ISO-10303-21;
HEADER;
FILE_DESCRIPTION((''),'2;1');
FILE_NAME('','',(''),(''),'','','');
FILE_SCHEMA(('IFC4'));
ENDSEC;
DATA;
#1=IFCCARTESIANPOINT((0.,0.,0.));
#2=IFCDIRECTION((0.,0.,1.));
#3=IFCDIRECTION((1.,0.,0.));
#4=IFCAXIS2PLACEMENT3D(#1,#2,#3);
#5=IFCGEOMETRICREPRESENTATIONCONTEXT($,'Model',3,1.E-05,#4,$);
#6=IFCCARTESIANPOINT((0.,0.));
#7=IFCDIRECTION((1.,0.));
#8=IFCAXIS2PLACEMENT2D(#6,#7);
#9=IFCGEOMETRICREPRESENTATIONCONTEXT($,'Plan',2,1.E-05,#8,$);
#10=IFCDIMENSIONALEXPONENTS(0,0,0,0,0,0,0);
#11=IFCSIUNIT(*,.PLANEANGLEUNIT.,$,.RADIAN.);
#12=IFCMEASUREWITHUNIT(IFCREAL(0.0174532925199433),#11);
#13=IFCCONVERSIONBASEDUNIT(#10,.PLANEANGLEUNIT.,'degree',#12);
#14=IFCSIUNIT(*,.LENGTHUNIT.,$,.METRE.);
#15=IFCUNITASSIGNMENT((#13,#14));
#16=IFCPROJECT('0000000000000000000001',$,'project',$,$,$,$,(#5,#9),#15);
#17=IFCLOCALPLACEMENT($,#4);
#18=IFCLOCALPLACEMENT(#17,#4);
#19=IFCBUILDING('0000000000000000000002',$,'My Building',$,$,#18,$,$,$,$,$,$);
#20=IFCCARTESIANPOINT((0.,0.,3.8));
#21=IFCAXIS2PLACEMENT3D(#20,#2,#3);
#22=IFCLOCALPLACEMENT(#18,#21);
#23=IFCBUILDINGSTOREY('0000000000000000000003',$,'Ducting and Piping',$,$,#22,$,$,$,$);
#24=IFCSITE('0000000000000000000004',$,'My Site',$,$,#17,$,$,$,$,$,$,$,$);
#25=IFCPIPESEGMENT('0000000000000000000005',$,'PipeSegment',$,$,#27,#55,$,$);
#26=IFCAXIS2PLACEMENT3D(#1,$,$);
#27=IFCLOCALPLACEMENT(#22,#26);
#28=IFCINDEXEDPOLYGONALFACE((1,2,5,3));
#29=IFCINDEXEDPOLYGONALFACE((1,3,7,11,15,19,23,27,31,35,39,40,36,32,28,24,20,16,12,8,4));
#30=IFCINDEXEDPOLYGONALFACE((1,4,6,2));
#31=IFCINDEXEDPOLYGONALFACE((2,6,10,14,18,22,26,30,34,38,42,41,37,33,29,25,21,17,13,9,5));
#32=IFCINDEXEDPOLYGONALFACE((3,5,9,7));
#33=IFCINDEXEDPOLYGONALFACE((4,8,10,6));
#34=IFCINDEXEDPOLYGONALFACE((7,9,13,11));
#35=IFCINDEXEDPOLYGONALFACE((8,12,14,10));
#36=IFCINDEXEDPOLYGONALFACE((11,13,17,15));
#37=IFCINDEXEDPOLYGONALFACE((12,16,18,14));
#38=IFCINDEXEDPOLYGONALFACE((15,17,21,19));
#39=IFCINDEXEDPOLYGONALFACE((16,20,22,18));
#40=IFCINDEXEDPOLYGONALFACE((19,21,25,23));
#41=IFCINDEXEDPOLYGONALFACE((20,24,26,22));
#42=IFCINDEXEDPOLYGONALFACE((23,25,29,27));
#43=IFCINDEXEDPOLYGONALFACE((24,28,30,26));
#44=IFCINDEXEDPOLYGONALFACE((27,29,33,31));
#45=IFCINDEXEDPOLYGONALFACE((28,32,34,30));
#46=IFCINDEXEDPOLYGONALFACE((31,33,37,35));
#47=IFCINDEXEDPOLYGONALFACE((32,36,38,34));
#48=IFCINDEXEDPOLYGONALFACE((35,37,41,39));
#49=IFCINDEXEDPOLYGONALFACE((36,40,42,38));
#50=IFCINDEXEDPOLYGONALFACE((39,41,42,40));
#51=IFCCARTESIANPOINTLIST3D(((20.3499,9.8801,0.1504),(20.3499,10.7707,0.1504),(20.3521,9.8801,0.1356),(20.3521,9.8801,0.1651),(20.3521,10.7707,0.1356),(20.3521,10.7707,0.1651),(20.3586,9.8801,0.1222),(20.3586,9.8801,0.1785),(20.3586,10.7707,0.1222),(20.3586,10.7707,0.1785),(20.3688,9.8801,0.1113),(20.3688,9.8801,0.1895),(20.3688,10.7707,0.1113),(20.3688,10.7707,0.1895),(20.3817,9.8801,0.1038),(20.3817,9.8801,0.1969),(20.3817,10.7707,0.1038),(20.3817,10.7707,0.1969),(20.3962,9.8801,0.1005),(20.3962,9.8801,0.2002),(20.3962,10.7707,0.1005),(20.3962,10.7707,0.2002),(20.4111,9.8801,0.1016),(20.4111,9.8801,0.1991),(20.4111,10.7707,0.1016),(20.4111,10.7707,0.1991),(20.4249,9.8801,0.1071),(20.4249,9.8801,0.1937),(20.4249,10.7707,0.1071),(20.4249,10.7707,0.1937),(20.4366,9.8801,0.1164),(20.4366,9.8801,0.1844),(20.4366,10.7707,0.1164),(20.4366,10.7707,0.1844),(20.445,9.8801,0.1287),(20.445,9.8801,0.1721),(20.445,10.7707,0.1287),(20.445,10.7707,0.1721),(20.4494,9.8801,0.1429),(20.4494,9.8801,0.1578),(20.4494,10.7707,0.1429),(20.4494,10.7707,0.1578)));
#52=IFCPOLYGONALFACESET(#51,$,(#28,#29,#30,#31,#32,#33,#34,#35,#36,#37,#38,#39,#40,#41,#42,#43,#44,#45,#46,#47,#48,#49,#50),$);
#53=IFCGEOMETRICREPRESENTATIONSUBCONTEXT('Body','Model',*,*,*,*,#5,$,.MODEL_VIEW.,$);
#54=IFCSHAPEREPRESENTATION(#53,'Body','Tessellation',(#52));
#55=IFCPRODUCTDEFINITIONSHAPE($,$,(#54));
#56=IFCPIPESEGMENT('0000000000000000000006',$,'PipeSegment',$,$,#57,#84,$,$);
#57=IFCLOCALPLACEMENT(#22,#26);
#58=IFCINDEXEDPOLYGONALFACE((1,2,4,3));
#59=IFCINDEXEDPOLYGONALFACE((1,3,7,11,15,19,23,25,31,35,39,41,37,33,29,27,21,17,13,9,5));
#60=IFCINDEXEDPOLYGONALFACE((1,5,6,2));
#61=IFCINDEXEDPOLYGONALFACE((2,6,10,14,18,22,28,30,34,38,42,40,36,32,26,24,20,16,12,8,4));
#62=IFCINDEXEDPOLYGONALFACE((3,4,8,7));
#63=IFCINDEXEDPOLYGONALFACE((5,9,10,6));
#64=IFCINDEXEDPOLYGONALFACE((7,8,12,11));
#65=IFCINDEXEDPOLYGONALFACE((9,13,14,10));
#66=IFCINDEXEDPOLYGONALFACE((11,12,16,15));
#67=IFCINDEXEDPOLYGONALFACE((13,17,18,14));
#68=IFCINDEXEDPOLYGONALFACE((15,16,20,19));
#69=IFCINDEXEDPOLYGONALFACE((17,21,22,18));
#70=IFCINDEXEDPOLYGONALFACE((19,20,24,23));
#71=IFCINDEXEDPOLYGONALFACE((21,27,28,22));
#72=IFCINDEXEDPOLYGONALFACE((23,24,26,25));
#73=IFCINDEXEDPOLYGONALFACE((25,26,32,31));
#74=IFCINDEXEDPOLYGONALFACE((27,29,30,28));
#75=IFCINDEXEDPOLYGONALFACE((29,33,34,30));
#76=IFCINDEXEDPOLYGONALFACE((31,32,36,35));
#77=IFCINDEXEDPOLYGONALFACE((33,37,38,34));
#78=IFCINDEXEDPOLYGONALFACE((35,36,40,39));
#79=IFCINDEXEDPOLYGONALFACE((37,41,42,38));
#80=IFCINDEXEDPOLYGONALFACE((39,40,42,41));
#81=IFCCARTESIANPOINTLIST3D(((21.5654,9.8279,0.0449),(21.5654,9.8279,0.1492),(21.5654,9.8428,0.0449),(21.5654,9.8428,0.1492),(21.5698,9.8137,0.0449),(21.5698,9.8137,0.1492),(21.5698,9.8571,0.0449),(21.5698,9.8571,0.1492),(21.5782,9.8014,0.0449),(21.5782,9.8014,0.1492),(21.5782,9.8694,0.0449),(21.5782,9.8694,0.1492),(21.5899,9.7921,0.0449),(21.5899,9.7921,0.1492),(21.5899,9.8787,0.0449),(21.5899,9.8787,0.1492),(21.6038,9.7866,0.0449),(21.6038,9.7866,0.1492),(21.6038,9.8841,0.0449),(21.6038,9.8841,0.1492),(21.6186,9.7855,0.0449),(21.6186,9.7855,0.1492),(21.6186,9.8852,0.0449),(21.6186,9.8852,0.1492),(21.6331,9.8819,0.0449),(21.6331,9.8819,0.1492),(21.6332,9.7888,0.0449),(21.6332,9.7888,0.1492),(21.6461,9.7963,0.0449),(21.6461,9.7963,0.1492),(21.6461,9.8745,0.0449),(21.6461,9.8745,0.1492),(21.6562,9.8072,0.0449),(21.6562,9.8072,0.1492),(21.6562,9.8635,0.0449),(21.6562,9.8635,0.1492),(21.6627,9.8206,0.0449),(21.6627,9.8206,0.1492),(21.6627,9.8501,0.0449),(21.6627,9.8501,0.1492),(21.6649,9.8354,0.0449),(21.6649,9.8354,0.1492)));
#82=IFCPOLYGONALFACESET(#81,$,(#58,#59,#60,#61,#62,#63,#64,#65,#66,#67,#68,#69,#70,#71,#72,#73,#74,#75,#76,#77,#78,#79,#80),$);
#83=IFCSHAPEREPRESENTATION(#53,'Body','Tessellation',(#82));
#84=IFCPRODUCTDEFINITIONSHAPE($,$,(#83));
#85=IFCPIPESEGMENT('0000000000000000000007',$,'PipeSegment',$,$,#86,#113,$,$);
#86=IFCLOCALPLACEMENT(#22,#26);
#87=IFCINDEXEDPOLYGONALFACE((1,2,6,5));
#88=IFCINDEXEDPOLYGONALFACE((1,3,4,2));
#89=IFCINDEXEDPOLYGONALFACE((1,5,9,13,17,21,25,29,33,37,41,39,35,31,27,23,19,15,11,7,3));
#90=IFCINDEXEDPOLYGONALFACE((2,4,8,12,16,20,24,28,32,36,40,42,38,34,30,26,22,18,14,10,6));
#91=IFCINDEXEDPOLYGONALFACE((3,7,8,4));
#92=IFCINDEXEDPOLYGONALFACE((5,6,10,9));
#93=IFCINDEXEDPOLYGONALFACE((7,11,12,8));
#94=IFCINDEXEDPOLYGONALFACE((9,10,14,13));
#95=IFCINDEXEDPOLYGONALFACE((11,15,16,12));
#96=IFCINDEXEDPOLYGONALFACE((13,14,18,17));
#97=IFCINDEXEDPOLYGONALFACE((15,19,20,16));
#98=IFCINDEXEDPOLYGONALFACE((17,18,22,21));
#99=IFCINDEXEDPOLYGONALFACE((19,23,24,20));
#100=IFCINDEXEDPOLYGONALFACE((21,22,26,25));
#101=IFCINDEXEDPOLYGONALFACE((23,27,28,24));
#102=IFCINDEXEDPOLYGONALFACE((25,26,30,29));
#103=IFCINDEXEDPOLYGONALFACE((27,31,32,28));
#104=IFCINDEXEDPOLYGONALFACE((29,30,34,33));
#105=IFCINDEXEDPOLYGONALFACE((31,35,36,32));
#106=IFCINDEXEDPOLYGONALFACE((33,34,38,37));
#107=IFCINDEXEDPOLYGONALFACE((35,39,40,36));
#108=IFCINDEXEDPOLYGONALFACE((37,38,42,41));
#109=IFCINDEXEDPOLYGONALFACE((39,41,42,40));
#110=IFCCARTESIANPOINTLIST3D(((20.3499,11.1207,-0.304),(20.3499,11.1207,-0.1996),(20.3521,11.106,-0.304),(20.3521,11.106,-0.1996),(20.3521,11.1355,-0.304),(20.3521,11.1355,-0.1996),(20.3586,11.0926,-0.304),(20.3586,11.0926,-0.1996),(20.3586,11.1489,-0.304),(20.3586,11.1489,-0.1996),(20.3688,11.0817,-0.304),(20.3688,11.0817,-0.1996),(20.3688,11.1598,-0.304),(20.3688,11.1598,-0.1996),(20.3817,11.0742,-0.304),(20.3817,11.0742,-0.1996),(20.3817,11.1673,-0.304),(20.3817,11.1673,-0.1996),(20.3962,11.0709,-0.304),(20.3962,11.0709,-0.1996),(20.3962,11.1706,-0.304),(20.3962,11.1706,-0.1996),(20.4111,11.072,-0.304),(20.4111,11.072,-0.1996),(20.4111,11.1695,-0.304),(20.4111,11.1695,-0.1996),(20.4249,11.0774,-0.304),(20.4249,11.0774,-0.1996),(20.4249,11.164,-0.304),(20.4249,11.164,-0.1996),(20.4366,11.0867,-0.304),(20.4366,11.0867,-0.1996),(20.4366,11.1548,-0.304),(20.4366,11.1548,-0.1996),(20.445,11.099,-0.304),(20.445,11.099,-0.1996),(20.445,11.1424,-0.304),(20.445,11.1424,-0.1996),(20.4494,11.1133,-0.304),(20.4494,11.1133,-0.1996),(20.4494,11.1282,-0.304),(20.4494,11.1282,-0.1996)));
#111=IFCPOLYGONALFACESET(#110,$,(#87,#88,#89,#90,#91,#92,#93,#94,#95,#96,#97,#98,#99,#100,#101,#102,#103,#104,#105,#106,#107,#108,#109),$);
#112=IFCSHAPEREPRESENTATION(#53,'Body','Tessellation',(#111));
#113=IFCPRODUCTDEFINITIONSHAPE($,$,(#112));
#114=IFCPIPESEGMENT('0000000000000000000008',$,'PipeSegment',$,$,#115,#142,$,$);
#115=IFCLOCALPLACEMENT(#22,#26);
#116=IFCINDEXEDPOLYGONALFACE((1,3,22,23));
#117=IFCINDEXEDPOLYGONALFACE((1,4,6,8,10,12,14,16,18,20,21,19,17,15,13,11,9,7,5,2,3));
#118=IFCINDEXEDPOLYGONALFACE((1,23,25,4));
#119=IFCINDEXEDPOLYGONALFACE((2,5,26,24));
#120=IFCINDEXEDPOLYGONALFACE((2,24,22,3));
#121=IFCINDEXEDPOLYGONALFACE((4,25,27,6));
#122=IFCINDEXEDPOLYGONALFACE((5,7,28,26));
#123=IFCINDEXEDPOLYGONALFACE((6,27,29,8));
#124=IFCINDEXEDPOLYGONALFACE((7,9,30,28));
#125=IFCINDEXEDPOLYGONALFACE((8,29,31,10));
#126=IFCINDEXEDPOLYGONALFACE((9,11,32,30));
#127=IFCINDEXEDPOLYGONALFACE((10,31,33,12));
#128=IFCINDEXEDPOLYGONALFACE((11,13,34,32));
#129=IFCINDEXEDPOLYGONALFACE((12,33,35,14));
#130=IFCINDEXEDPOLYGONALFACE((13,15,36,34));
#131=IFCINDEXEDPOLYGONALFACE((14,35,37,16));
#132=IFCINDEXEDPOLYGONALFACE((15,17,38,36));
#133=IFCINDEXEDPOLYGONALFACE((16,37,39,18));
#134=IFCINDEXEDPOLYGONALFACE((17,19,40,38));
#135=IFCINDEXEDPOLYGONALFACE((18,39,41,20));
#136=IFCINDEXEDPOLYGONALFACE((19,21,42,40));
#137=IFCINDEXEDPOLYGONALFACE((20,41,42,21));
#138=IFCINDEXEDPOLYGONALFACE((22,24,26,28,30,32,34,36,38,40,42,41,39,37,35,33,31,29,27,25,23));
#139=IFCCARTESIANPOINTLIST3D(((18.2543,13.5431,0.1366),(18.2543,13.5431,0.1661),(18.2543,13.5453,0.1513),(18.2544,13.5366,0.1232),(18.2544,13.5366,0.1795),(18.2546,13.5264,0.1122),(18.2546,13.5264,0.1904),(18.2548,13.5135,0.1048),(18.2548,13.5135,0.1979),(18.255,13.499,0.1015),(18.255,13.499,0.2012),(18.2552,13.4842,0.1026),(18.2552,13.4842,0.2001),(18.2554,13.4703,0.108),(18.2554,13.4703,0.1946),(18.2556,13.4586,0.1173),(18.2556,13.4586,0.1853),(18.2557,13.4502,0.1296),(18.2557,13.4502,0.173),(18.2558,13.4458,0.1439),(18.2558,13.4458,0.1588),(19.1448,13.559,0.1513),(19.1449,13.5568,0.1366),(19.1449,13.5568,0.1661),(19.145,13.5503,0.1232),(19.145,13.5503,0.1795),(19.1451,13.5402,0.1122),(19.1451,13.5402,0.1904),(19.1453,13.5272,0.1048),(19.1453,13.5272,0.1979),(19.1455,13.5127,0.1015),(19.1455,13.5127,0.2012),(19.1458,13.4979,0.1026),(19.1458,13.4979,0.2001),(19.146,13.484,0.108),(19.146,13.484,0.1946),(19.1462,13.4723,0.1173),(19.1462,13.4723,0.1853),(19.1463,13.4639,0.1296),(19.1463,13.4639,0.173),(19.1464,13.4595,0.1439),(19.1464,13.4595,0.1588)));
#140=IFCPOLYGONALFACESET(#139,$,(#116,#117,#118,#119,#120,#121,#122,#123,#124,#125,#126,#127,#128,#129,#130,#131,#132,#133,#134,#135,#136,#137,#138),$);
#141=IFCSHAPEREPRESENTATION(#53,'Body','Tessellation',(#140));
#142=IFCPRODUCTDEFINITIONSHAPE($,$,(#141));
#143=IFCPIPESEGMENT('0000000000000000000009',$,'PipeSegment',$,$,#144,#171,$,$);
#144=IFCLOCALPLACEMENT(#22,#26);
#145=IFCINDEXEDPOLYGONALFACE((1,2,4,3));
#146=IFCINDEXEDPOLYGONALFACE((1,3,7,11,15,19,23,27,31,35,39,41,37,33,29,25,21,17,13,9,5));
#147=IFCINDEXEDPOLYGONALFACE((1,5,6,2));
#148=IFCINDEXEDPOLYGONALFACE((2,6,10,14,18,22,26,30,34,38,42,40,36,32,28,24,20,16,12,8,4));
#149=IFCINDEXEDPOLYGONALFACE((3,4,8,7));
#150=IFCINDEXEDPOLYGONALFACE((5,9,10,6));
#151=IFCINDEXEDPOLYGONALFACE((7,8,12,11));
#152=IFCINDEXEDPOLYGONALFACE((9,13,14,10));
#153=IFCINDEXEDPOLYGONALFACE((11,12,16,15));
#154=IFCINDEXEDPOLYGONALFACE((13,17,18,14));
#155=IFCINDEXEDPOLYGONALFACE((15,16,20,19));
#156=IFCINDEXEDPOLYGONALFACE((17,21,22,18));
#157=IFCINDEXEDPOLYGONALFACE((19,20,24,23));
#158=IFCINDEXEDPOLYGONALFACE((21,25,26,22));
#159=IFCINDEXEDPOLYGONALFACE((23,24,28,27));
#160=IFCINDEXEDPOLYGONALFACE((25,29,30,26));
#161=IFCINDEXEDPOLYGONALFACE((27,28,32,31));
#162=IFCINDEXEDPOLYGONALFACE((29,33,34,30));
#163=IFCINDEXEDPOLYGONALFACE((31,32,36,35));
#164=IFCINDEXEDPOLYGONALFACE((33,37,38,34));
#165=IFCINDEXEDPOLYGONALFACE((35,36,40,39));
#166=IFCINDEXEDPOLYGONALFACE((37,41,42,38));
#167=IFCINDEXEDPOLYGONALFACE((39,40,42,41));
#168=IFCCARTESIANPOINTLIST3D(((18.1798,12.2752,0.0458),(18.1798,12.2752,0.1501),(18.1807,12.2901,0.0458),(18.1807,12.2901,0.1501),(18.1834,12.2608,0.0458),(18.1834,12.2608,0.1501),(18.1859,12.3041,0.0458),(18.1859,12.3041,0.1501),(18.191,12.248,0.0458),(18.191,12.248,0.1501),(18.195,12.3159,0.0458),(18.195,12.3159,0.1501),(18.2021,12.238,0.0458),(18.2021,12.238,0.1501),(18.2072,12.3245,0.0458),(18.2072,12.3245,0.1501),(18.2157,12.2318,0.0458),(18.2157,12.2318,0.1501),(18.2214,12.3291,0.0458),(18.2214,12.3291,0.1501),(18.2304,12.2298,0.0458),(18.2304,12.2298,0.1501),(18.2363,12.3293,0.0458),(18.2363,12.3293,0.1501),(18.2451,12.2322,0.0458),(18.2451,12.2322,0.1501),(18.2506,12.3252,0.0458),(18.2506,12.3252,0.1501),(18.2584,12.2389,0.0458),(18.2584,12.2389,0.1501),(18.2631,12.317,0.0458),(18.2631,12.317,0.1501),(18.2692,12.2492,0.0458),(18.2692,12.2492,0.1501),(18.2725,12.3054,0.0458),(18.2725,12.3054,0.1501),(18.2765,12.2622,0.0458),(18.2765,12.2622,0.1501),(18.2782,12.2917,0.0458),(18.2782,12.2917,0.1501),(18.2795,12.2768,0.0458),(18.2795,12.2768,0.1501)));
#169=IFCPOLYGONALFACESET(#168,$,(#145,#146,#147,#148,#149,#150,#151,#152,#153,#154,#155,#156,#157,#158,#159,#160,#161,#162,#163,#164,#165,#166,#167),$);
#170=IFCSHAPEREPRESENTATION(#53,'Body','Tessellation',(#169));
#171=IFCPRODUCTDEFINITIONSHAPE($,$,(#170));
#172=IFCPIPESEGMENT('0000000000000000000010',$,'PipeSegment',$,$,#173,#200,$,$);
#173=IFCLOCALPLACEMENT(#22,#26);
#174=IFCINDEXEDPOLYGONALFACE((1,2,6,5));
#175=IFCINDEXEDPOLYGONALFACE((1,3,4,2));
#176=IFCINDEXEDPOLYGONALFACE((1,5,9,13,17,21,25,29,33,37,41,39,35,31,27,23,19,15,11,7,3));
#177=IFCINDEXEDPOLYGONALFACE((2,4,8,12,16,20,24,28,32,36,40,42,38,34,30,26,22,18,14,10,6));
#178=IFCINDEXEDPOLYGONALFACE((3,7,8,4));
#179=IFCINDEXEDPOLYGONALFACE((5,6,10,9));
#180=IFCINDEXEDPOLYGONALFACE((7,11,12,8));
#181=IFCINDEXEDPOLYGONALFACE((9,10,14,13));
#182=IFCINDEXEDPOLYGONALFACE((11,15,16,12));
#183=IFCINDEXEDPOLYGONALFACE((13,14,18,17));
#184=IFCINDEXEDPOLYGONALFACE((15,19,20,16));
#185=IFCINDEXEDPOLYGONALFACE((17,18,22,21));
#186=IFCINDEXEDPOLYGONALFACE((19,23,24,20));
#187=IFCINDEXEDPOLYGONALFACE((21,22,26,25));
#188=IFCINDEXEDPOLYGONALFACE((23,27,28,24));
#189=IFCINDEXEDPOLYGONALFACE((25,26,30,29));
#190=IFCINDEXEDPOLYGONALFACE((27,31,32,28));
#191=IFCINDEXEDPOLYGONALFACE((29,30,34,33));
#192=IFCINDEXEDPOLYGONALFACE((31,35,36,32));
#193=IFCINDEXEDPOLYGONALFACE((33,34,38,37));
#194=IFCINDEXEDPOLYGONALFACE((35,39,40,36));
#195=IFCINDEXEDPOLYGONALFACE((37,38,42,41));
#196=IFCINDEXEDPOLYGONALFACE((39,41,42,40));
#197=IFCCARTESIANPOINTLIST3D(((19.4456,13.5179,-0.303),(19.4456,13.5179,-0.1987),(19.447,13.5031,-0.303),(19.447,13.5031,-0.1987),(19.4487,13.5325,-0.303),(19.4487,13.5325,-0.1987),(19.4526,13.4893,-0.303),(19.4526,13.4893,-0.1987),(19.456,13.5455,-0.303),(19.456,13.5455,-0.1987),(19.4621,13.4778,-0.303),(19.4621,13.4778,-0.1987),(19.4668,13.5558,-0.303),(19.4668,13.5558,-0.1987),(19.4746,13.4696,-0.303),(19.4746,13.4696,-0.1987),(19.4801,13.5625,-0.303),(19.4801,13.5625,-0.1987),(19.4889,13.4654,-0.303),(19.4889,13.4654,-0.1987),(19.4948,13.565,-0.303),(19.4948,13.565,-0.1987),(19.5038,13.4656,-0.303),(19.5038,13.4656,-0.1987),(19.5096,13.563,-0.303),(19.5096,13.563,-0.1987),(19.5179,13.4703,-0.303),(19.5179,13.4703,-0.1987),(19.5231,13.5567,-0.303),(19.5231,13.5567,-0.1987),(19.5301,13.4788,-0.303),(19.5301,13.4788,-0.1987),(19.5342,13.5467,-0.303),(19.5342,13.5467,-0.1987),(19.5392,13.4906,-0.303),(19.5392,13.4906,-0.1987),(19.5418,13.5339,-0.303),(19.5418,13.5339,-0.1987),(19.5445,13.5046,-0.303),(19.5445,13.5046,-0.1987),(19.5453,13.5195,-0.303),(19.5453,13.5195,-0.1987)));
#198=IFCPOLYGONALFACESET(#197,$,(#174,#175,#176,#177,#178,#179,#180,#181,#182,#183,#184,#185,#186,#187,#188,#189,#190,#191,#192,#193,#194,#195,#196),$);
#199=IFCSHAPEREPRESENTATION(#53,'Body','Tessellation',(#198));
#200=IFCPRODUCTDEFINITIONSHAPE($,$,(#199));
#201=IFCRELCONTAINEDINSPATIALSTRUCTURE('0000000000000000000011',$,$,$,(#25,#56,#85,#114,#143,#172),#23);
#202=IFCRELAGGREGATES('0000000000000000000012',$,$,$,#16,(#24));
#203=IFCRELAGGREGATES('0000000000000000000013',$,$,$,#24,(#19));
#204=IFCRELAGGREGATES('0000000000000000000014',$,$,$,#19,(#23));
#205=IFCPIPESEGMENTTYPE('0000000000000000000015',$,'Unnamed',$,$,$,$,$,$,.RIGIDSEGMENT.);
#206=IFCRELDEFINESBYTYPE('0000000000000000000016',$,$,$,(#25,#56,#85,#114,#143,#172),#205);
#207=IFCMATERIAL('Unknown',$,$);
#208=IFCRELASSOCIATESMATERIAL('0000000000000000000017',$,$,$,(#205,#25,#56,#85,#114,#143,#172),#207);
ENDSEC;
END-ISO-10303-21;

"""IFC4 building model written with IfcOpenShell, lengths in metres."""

from ifc_helpers import new_model, entity, si_unit, converted_unit, frame, origin_with_axes, origin_2d_with_axis, place, context, subcontext, project, spatial, circle, extrude, material, material_profile, profile_set, profile_usage, type_object, element, save


model = new_model("IFC4")

# Units and contexts
model_context = context("Model", 3, precision=1e-05, world=origin_with_axes())
plan_context = context("Plan", 2, precision=1e-05, world=origin_2d_with_axis())
body_context = subcontext(model_context, "Body", "Model", "MODEL_VIEW")
ifc_project = project(units=[converted_unit("PLANEANGLEUNIT", "degree", entity("IfcReal", 0.0174532925199433), si_unit("PLANEANGLEUNIT", "RADIAN"), dimensions=[0, 0, 0, 0, 0, 0, 0]), si_unit("LENGTHUNIT", "METRE")], contexts=[model_context, plan_context])

# Site, building, storey
site_placement = place(None, origin_with_axes())
site = spatial("IfcSite", under=ifc_project, at=site_placement, Name="My Site")
building_placement = place(site_placement, origin_with_axes())
building = spatial("IfcBuilding", under=site, at=building_placement, Name="My Building")
storey_placement = place(building_placement, frame((0.0, 0.0, 3.8), z_axis=(0.0, 0.0, 1.0), x_axis=(1.0, 0.0, 0.0)))
storey = spatial("IfcBuildingStorey", under=building, at=storey_placement, Name="Ducting and Piping")

# Pipe segments
ifc_material = material(Name="Unknown")
ifc_material_profile_1 = material_profile(ifc_material, circle(Radius=0.05))
ifc_profile_set_1 = profile_set([ifc_material_profile_1])
ifc_profile_usage_1 = profile_usage(ifc_profile_set_1, cardinal=5)
pipe_segment_type = type_object("IfcPipeSegmentType", Name="Unnamed", PredefinedType="RIGIDSEGMENT", material=ifc_profile_set_1)
pipe_segment_1_placement = place(storey_placement, frame((20.3999, 9.8801, 0.1504), z_axis=(0.0, 1.0, 0.0), x_axis=(-1.0, 0.0, 0.0)))
element("IfcPipeSegment", 1, at=pipe_segment_1_placement, inside=storey, type_object=pipe_segment_type, material=ifc_profile_usage_1, Name="PipeSegment", context=body_context, shape_type="SweptSolid", body=[
    extrude(circle(Radius=0.05), origin_with_axes(), (0.0, 0.0, 1.0), 0.8907),
])
ifc_profile_usage_2 = profile_usage(ifc_profile_set_1, cardinal=5)
pipe_segment_2_placement = place(storey_placement, frame((21.6149, 9.8354, 0.0449), z_axis=(0.0, 0.0, 1.0), x_axis=(1.0, 0.00006, 0.0)))
element("IfcPipeSegment", 2, at=pipe_segment_2_placement, inside=storey, type_object=pipe_segment_type, material=ifc_profile_usage_2, Name="PipeSegment", context=body_context, shape_type="SweptSolid", body=[
    extrude(circle(Radius=0.05), origin_with_axes(), (0.0, 0.0, 1.0), 0.1043),
])
ifc_profile_usage_3 = profile_usage(ifc_profile_set_1, cardinal=5)
pipe_segment_3_placement = place(storey_placement, frame((20.3999, 11.1207, -0.304), z_axis=(0.0, 0.0, 1.0), x_axis=(-1.0, 0.0, 0.0)))
element("IfcPipeSegment", 3, at=pipe_segment_3_placement, inside=storey, type_object=pipe_segment_type, material=ifc_profile_usage_3, Name="PipeSegment", context=body_context, shape_type="SweptSolid", body=[
    extrude(circle(Radius=0.05), origin_with_axes(), (0.0, 0.0, 1.0), 0.1043),
])
ifc_profile_usage_4 = profile_usage(ifc_profile_set_1, cardinal=5)
pipe_segment_4_placement = place(storey_placement, frame((18.2551, 13.4953, 0.1513), z_axis=(0.999882, 0.015389, 0.0), x_axis=(-0.015389, 0.999882, 0.0)))
element("IfcPipeSegment", 4, at=pipe_segment_4_placement, inside=storey, type_object=pipe_segment_type, material=ifc_profile_usage_4, Name="PipeSegment", context=body_context, shape_type="SweptSolid", body=[
    extrude(circle(Radius=0.05), origin_with_axes(), (0.0, 0.0, 1.0), 0.8907),
])
ifc_profile_usage_5 = profile_usage(ifc_profile_set_1, cardinal=5)
pipe_segment_5_placement = place(storey_placement, frame((18.2296, 12.2798, 0.0458), z_axis=(0.0, 0.0, 1.0), x_axis=(0.015928, -0.999873, 0.0)))
element("IfcPipeSegment", 5, at=pipe_segment_5_placement, inside=storey, type_object=pipe_segment_type, material=ifc_profile_usage_5, Name="PipeSegment", context=body_context, shape_type="SweptSolid", body=[
    extrude(circle(Radius=0.05), origin_with_axes(), (0.0, 0.0, 1.0), 0.1043),
])
ifc_profile_usage_6 = profile_usage(ifc_profile_set_1, cardinal=5)
pipe_segment_6_placement = place(storey_placement, frame((19.4956, 13.515, -0.303), z_axis=(0.0, 0.0, 1.0), x_axis=(-0.015371, 0.999882, 0.0)))
element("IfcPipeSegment", 6, at=pipe_segment_6_placement, inside=storey, type_object=pipe_segment_type, material=ifc_profile_usage_6, Name="PipeSegment", context=body_context, shape_type="SweptSolid", body=[
    extrude(circle(Radius=0.05), origin_with_axes(), (0.0, 0.0, 1.0), 0.1043),
])

save(model, "model.ifc")
